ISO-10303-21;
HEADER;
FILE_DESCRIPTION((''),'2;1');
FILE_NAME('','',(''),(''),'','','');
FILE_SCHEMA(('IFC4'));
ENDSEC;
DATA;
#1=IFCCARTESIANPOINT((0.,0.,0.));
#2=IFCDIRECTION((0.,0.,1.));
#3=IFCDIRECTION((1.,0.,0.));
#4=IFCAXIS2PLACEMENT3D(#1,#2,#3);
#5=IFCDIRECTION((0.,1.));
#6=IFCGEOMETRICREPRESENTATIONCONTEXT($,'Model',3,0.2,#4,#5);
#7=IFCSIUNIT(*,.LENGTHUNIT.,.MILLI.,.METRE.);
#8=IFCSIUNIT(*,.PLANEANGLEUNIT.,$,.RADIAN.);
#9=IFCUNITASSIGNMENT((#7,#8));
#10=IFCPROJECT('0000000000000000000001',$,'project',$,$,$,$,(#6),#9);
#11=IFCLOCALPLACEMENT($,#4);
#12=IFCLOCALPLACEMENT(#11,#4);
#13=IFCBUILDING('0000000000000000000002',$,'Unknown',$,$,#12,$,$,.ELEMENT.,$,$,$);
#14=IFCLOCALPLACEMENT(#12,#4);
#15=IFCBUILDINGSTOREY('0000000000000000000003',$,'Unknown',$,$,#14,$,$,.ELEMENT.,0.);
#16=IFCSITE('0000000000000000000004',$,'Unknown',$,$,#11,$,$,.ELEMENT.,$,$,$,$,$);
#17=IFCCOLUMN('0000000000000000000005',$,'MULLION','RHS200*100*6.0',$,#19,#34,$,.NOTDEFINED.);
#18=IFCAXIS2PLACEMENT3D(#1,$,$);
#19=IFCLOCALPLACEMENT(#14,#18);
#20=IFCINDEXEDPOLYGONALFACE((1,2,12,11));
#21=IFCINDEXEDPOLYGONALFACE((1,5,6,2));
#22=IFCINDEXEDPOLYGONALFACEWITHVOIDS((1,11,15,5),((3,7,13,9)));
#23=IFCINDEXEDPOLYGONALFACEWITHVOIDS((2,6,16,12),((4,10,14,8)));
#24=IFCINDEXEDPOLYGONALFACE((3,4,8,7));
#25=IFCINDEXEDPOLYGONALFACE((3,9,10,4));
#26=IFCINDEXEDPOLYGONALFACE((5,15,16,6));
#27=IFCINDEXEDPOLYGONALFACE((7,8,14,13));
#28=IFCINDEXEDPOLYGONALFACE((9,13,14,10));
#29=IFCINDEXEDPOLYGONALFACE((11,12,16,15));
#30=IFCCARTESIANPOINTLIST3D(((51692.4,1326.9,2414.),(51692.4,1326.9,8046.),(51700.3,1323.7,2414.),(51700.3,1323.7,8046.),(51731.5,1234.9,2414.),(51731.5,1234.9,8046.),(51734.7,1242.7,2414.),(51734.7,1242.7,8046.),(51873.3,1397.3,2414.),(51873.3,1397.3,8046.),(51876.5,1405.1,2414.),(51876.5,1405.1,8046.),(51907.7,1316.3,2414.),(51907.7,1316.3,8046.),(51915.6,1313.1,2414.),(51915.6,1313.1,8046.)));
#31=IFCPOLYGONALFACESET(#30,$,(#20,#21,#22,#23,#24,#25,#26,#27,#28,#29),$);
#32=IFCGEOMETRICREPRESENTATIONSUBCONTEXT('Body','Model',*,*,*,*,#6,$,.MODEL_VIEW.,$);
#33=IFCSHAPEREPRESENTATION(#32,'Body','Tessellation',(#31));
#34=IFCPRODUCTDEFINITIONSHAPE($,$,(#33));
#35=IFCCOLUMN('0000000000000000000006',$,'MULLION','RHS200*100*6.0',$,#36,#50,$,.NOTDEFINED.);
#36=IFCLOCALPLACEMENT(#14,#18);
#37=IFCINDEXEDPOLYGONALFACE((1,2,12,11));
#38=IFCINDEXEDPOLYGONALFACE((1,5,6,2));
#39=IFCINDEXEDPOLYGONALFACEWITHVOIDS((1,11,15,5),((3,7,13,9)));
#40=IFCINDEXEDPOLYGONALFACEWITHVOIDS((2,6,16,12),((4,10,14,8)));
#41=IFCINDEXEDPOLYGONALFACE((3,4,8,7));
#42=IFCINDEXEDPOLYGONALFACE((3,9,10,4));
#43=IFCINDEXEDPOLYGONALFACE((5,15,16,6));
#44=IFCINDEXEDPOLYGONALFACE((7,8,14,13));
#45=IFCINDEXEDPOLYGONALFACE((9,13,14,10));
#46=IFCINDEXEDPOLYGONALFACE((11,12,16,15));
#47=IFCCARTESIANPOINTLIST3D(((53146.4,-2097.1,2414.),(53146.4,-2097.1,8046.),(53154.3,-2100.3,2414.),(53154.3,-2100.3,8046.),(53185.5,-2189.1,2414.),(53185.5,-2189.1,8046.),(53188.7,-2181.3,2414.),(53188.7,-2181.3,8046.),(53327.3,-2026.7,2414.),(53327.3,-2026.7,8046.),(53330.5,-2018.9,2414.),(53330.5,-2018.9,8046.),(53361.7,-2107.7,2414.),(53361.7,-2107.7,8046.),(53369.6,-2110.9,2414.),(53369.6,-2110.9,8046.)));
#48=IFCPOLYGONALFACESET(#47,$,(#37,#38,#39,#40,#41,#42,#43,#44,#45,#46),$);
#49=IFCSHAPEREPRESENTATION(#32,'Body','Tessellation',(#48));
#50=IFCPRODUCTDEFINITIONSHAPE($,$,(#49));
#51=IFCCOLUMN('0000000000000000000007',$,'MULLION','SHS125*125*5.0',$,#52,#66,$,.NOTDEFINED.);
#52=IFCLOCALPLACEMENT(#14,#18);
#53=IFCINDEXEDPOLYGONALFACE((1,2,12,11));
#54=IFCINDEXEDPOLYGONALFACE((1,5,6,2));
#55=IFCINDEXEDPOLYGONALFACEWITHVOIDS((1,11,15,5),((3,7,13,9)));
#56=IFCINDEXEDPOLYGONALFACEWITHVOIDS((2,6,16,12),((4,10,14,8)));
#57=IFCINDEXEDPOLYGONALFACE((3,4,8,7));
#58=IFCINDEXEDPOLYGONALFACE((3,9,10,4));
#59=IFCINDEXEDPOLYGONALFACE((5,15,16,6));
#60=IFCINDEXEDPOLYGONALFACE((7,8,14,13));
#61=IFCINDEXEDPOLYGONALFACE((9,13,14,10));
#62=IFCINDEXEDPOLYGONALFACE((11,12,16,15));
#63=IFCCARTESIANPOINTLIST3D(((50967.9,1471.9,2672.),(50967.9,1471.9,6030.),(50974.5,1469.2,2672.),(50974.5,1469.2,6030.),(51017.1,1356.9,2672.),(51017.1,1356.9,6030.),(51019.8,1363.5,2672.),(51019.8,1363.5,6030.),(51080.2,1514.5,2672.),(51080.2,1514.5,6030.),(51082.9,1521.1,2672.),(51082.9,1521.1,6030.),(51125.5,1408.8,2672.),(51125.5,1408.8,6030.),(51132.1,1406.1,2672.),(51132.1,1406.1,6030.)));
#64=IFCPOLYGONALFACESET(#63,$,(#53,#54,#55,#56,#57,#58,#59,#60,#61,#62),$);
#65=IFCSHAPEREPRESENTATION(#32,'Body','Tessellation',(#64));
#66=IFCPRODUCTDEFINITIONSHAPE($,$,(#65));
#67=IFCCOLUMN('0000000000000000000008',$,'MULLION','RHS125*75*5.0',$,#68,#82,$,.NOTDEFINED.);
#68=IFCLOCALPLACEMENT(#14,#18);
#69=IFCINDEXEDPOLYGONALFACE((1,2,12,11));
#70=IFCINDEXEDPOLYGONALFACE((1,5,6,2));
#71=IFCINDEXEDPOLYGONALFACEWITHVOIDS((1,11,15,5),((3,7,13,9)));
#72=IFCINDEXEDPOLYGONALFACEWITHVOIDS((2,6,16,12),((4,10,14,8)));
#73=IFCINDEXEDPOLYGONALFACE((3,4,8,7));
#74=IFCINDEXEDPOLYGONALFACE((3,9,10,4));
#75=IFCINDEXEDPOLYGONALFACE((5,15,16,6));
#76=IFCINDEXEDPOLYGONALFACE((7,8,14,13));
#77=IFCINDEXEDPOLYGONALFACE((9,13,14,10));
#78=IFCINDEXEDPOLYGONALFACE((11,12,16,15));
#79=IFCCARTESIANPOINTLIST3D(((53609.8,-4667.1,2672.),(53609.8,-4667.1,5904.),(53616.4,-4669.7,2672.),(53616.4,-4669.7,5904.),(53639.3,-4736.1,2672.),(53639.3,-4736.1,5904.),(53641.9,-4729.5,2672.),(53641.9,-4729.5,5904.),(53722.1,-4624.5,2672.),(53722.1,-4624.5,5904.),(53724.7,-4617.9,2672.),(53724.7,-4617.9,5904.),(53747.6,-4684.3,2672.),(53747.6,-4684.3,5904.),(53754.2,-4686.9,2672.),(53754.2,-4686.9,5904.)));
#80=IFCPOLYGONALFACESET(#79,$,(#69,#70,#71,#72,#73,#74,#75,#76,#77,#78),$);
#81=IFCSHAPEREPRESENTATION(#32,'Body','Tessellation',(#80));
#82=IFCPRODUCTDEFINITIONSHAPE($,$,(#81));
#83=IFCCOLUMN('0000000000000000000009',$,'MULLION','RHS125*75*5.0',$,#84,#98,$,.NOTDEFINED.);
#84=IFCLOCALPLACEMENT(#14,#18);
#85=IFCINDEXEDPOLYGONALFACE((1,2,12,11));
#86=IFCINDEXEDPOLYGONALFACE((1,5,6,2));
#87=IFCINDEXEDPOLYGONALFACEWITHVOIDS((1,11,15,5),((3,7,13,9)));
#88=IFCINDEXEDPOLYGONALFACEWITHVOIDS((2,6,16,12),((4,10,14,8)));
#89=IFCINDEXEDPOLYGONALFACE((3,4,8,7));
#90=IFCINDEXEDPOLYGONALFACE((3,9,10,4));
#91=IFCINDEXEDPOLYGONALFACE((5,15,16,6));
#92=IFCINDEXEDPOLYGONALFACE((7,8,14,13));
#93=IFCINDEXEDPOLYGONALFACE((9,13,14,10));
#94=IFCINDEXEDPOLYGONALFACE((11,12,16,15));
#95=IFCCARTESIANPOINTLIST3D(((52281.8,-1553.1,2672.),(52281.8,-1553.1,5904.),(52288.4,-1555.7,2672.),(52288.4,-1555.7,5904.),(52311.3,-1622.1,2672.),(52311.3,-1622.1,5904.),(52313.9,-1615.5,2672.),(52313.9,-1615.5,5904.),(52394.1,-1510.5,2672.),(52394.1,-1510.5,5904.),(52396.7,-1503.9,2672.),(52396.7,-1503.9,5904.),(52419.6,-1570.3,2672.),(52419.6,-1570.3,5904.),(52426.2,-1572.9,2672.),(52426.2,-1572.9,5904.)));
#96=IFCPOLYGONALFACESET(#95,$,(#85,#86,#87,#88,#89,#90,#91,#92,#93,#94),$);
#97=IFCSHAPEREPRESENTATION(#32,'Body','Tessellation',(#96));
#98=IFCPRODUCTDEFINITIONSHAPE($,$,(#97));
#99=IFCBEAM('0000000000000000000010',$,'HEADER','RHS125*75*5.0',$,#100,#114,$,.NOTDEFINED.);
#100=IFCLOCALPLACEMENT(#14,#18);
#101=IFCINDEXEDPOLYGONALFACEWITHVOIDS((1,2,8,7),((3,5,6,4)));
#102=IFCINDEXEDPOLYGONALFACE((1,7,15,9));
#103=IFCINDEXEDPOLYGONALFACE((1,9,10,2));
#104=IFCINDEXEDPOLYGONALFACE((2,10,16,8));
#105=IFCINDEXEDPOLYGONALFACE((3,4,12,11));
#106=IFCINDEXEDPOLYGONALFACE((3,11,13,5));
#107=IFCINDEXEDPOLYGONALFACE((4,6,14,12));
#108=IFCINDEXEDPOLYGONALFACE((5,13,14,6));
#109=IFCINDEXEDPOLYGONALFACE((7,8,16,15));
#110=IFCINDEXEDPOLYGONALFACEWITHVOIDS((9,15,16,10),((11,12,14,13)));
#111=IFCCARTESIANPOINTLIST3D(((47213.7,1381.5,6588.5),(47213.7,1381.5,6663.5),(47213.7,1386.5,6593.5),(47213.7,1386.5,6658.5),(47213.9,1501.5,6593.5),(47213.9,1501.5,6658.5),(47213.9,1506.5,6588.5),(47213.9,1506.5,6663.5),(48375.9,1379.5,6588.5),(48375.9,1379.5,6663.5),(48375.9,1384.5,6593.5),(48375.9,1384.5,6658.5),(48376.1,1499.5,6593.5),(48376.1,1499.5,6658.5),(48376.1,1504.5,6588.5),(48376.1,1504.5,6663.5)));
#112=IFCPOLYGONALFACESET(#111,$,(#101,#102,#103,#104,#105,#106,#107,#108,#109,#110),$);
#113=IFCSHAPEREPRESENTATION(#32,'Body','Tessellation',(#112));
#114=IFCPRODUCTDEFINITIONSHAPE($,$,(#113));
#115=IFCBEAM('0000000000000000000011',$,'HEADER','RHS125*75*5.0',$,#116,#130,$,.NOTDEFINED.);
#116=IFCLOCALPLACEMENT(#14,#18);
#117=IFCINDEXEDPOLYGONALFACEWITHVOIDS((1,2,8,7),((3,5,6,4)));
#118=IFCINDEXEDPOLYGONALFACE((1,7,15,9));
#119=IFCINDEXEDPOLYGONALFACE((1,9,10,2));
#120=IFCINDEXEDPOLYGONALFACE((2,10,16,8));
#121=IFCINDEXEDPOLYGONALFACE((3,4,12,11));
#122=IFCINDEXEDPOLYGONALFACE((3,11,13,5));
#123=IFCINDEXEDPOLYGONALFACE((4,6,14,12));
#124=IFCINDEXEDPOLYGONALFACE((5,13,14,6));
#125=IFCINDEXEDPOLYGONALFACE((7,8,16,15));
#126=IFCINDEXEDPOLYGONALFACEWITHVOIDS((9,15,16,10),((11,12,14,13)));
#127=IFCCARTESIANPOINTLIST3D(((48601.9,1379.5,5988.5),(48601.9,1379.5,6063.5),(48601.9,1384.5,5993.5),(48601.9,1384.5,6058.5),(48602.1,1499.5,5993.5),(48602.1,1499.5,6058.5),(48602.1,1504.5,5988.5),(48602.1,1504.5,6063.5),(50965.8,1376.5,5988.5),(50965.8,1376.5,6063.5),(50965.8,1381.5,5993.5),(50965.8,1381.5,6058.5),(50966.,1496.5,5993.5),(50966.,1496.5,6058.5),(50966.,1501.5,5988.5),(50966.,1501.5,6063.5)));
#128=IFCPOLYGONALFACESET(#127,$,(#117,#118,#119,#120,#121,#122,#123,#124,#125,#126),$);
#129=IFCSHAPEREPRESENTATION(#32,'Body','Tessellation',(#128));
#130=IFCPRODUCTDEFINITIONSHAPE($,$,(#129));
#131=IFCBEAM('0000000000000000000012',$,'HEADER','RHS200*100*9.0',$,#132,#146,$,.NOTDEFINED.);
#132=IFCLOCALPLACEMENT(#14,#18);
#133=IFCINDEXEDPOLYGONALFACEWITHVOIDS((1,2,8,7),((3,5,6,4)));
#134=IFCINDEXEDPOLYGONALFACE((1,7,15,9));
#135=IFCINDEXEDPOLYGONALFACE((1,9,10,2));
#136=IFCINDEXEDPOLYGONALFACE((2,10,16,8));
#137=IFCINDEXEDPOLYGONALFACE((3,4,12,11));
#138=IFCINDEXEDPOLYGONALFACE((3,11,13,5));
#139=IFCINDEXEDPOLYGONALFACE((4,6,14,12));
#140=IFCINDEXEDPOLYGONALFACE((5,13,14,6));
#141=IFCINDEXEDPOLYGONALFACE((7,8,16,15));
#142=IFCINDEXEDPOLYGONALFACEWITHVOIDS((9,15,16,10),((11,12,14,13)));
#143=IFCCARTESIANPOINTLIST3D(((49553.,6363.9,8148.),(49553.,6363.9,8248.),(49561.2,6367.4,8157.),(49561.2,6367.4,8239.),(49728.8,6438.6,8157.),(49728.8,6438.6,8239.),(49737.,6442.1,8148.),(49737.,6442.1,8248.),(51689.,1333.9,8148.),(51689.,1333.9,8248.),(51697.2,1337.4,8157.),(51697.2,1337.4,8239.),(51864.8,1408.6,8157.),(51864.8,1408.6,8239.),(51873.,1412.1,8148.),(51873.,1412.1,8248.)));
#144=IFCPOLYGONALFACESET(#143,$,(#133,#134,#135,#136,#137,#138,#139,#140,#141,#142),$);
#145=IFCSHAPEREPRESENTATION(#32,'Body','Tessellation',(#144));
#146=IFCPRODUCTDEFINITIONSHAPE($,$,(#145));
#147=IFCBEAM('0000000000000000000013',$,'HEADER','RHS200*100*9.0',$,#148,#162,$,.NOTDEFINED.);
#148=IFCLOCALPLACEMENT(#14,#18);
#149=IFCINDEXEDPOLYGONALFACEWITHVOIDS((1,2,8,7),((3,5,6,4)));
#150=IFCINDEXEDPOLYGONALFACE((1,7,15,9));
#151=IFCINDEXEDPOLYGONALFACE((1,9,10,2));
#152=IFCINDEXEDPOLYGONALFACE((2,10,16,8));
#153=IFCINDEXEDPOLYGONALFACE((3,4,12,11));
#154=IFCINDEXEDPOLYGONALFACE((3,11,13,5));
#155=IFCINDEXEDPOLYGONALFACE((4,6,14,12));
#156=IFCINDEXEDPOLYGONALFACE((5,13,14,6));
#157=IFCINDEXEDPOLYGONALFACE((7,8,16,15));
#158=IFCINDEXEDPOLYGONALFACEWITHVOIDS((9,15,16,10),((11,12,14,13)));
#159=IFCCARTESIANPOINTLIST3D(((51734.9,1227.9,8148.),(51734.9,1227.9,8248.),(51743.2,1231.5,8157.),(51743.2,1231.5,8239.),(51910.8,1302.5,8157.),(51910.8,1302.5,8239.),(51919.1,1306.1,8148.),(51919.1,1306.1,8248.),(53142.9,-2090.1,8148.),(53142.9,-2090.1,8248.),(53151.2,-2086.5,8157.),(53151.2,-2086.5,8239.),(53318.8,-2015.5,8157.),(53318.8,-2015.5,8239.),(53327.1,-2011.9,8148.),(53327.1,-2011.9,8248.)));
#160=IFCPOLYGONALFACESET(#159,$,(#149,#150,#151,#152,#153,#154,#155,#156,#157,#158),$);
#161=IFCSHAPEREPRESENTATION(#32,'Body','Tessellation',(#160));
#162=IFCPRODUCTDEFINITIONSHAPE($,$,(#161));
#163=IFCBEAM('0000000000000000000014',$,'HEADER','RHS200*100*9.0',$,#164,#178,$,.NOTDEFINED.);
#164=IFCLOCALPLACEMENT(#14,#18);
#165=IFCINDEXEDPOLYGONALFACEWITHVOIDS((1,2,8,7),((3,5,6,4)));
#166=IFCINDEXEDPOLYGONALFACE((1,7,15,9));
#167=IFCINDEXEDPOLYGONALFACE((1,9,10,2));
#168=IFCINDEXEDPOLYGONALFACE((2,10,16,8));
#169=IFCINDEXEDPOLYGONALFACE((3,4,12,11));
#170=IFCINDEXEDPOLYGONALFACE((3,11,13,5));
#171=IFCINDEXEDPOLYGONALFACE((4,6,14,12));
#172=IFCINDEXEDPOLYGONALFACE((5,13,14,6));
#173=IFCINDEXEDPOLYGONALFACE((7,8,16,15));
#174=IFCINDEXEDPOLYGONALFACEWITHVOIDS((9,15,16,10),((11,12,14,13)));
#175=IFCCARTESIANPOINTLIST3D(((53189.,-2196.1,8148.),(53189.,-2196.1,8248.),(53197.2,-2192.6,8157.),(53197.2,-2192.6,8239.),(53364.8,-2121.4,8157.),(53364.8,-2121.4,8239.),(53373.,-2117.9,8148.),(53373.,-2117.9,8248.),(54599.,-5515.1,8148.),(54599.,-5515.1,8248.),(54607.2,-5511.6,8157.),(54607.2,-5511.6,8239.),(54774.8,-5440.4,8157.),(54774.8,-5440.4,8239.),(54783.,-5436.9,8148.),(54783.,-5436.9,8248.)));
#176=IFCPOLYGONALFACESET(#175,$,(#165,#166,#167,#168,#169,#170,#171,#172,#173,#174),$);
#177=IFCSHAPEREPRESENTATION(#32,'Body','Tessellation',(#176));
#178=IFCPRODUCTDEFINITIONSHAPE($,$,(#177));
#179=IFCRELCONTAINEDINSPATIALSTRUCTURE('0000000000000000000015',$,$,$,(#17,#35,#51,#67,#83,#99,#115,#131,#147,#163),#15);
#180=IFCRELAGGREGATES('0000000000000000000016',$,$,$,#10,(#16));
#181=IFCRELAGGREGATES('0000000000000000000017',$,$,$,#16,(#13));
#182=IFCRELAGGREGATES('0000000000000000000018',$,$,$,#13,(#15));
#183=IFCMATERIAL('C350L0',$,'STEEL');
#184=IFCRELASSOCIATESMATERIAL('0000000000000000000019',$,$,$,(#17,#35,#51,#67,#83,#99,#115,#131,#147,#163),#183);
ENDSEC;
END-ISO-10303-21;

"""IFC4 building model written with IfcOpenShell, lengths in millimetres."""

from ifc_helpers import new_model, si_unit, direction, frame, origin_with_axes, place, context, subcontext, project, spatial, line, indexed_curve, outline, extrude, material, element, save


model = new_model("IFC4")

# Units and contexts
model_context = context("Model", 3, precision=0.2, world=origin_with_axes(), true_north=direction((0.0, 1.0)))
body_context = subcontext(model_context, "Body", "Model", "MODEL_VIEW")
ifc_project = project(units=[si_unit("LENGTHUNIT", "METRE", prefix="MILLI"), si_unit("PLANEANGLEUNIT", "RADIAN")], contexts=[model_context])

# Site, building, storey
site_placement = place(None, origin_with_axes())
site = spatial("IfcSite", under=ifc_project, at=site_placement, Name="Unknown", CompositionType="ELEMENT")
building_placement = place(site_placement, origin_with_axes())
building = spatial("IfcBuilding", under=site, at=building_placement, Name="Unknown", CompositionType="ELEMENT")
storey_placement = place(building_placement, origin_with_axes())
storey = spatial("IfcBuildingStorey", under=building, at=storey_placement, Name="Unknown", CompositionType="ELEMENT", Elevation=0.0)

# Columns
ifc_material_1 = material(Name="C350L0", Category="STEEL")
for number, where, z_axis, x_axis, name in (
    (1, (51804.0, 1320.0, 2414.0), (0.391213, -0.9203, 0.0), (0.0, 0.0, 1.0), "MULLION"),
    (2, (53258.0, -2104.0, 2414.0), (0.391213, -0.9203, 0.0), (0.0, 0.0, 1.0), "MULLION"),
):
    element("IfcColumn", number, at=place(storey_placement, frame(where, z_axis=z_axis, x_axis=x_axis)), inside=storey, material=ifc_material_1, Name=name, Description="RHS200*100*6.0", PredefinedType="NOTDEFINED", context=body_context, shape_type="SolidModel", body=[
        extrude(outline(indexed_curve([(-50.0, -100.0), (50.0, -100.0), (50.0, 100.0), (-50.0, 100.0)], segments=[line(1, 2, 3, 4, 1)]), holes=[indexed_curve([(-44.0, -94.0), (-44.0, 94.0), (44.0, 94.0), (44.0, -94.0)], segments=[line(1, 2, 3, 4, 1)])]), frame((0.0, 0.0, 0.0), z_axis=(-1.0, 0.0, 0.0), x_axis=(0.0, 0.0, 1.0)), (0.0, 0.0, -1.0), 5632.0),
    ])
column_placement = place(storey_placement, frame((51050.0, 1439.0, 2672.0), z_axis=(0.919341, 0.393461, 0.0), x_axis=(0.0, 0.0, 1.0)))
element("IfcColumn", 3, at=column_placement, inside=storey, material=ifc_material_1, Name="MULLION", Description="SHS125*125*5.0", PredefinedType="NOTDEFINED", context=body_context, shape_type="SolidModel", body=[
    extrude(outline(indexed_curve([(-62.5, -62.5), (62.5, -62.5), (62.5, 62.5), (-62.5, 62.5)], segments=[line(1, 2, 3, 4, 1)]), holes=[indexed_curve([(-57.5, -57.5), (-57.5, 57.5), (57.5, 57.5), (57.5, -57.5)], segments=[line(1, 2, 3, 4, 1)])]), frame((0.0, 0.0, 0.0), z_axis=(-1.0, 0.0, 0.0), x_axis=(0.0, 0.0, 1.0)), (0.0, 0.0, -1.0), 3358.0),
])
for number, where, z_axis, x_axis, name in (
    (4, (53682.0, -4677.0, 2672.0), (0.39314, -0.919479, 0.0), (0.0, 0.0, 1.0), "MULLION"),
    (5, (52354.0, -1563.0, 2672.0), (0.39314, -0.919479, 0.0), (0.0, 0.0, 1.0), "MULLION"),
):
    element("IfcColumn", number, at=place(storey_placement, frame(where, z_axis=z_axis, x_axis=x_axis)), inside=storey, material=ifc_material_1, Name=name, Description="RHS125*75*5.0", PredefinedType="NOTDEFINED", context=body_context, shape_type="SolidModel", body=[
        extrude(outline(indexed_curve([(-37.5, -62.5), (37.5, -62.5), (37.5, 62.5), (-37.5, 62.5)], segments=[line(1, 2, 3, 4, 1)]), holes=[indexed_curve([(-32.5, -57.5), (-32.5, 57.5), (32.5, 57.5), (32.5, -57.5)], segments=[line(1, 2, 3, 4, 1)])]), frame((0.0, 0.0, 0.0), z_axis=(-1.0, 0.0, 0.0), x_axis=(0.0, 0.0, 1.0)), (0.0, 0.0, -1.0), 3232.0),
    ])

# Beams
beam_1_placement = place(storey_placement, frame((48376.0, 1442.0, 6626.0), z_axis=(0.0, 0.0, 1.0), x_axis=(-0.999999, 0.001721, 0.0)))
element("IfcBeam", 6, at=beam_1_placement, inside=storey, material=ifc_material_1, Name="HEADER", Description="RHS125*75*5.0", PredefinedType="NOTDEFINED", context=body_context, shape_type="SolidModel", body=[
    extrude(outline(indexed_curve([(-37.5, -62.5), (37.5, -62.5), (37.5, 62.5), (-37.5, 62.5)], segments=[line(1, 2, 3, 4, 1)]), holes=[indexed_curve([(-32.5, -57.5), (-32.5, 57.5), (32.5, 57.5), (32.5, -57.5)], segments=[line(1, 2, 3, 4, 1)])]), frame((0.0, 0.0, 0.0), z_axis=(-1.0, 0.0, 0.0), x_axis=(0.0, 0.0, 1.0)), (0.0, 0.0, -1.0), 1162.2),
])
beam_2_placement = place(storey_placement, frame((50965.9, 1439.0, 6026.0), z_axis=(0.0, 0.0, 1.0), x_axis=(-0.999999, 0.001269, 0.0)))
element("IfcBeam", 7, at=beam_2_placement, inside=storey, material=ifc_material_1, Name="HEADER", Description="RHS125*75*5.0", PredefinedType="NOTDEFINED", context=body_context, shape_type="SolidModel", body=[
    extrude(outline(indexed_curve([(-37.5, -62.5), (37.5, -62.5), (37.5, 62.5), (-37.5, 62.5)], segments=[line(1, 2, 3, 4, 1)]), holes=[indexed_curve([(-32.5, -57.5), (-32.5, 57.5), (32.5, 57.5), (32.5, -57.5)], segments=[line(1, 2, 3, 4, 1)])]), frame((0.0, 0.0, 0.0), z_axis=(-1.0, 0.0, 0.0), x_axis=(0.0, 0.0, 1.0)), (0.0, 0.0, -1.0), 2363.9),
])
beam_3_placement = place(storey_placement, frame((51781.0, 1373.0, 8198.0), z_axis=(0.0, 0.0, 1.0), x_axis=(-0.390869, 0.920446, 0.0)))
element("IfcBeam", 8, at=beam_3_placement, inside=storey, material=ifc_material_1, Name="HEADER", Description="RHS200*100*9.0", PredefinedType="NOTDEFINED", context=body_context, shape_type="SolidModel", body=[
    extrude(outline(indexed_curve([(-50.0, -100.0), (50.0, -100.0), (50.0, 100.0), (-50.0, 100.0)], segments=[line(1, 2, 3, 4, 1)]), holes=[indexed_curve([(-41.0, -91.0), (-41.0, 91.0), (41.0, 91.0), (41.0, -91.0)], segments=[line(1, 2, 3, 4, 1)])]), frame((0.0, 0.0, 0.0), z_axis=(-1.0, 0.0, 0.0), x_axis=(0.0, 0.0, 1.0)), (0.0, 0.0, -1.0), 5464.7),
])
beam_4_placement = place(storey_placement, frame((53235.0, -2051.0, 8198.0), z_axis=(0.0, 0.0, 1.0), x_axis=(-0.390635, 0.920546, 0.0)))
element("IfcBeam", 9, at=beam_4_placement, inside=storey, material=ifc_material_1, Name="HEADER", Description="RHS200*100*9.0", PredefinedType="NOTDEFINED", context=body_context, shape_type="SolidModel", body=[
    extrude(outline(indexed_curve([(-50.0, -100.0), (50.0, -100.0), (50.0, 100.0), (-50.0, 100.0)], segments=[line(1, 2, 3, 4, 1)]), holes=[indexed_curve([(-41.0, -91.0), (-41.0, 91.0), (41.0, 91.0), (41.0, -91.0)], segments=[line(1, 2, 3, 4, 1)])]), frame((0.0, 0.0, 0.0), z_axis=(-1.0, 0.0, 0.0), x_axis=(0.0, 0.0, 1.0)), (0.0, 0.0, -1.0), 3604.4),
])
beam_5_placement = place(storey_placement, frame((54691.0, -5476.0, 8198.0), z_axis=(0.0, 0.0, 1.0), x_axis=(-0.391006, 0.920388, 0.0)))
element("IfcBeam", 10, at=beam_5_placement, inside=storey, material=ifc_material_1, Name="HEADER", Description="RHS200*100*9.0", PredefinedType="NOTDEFINED", context=body_context, shape_type="SolidModel", body=[
    extrude(outline(indexed_curve([(-50.0, -100.0), (50.0, -100.0), (50.0, 100.0), (-50.0, 100.0)], segments=[line(1, 2, 3, 4, 1)]), holes=[indexed_curve([(-41.0, -91.0), (-41.0, 91.0), (41.0, 91.0), (41.0, -91.0)], segments=[line(1, 2, 3, 4, 1)])]), frame((0.0, 0.0, 0.0), z_axis=(-1.0, 0.0, 0.0), x_axis=(0.0, 0.0, 1.0)), (0.0, 0.0, -1.0), 3606.1),
])

save(model, "model.ifc")
